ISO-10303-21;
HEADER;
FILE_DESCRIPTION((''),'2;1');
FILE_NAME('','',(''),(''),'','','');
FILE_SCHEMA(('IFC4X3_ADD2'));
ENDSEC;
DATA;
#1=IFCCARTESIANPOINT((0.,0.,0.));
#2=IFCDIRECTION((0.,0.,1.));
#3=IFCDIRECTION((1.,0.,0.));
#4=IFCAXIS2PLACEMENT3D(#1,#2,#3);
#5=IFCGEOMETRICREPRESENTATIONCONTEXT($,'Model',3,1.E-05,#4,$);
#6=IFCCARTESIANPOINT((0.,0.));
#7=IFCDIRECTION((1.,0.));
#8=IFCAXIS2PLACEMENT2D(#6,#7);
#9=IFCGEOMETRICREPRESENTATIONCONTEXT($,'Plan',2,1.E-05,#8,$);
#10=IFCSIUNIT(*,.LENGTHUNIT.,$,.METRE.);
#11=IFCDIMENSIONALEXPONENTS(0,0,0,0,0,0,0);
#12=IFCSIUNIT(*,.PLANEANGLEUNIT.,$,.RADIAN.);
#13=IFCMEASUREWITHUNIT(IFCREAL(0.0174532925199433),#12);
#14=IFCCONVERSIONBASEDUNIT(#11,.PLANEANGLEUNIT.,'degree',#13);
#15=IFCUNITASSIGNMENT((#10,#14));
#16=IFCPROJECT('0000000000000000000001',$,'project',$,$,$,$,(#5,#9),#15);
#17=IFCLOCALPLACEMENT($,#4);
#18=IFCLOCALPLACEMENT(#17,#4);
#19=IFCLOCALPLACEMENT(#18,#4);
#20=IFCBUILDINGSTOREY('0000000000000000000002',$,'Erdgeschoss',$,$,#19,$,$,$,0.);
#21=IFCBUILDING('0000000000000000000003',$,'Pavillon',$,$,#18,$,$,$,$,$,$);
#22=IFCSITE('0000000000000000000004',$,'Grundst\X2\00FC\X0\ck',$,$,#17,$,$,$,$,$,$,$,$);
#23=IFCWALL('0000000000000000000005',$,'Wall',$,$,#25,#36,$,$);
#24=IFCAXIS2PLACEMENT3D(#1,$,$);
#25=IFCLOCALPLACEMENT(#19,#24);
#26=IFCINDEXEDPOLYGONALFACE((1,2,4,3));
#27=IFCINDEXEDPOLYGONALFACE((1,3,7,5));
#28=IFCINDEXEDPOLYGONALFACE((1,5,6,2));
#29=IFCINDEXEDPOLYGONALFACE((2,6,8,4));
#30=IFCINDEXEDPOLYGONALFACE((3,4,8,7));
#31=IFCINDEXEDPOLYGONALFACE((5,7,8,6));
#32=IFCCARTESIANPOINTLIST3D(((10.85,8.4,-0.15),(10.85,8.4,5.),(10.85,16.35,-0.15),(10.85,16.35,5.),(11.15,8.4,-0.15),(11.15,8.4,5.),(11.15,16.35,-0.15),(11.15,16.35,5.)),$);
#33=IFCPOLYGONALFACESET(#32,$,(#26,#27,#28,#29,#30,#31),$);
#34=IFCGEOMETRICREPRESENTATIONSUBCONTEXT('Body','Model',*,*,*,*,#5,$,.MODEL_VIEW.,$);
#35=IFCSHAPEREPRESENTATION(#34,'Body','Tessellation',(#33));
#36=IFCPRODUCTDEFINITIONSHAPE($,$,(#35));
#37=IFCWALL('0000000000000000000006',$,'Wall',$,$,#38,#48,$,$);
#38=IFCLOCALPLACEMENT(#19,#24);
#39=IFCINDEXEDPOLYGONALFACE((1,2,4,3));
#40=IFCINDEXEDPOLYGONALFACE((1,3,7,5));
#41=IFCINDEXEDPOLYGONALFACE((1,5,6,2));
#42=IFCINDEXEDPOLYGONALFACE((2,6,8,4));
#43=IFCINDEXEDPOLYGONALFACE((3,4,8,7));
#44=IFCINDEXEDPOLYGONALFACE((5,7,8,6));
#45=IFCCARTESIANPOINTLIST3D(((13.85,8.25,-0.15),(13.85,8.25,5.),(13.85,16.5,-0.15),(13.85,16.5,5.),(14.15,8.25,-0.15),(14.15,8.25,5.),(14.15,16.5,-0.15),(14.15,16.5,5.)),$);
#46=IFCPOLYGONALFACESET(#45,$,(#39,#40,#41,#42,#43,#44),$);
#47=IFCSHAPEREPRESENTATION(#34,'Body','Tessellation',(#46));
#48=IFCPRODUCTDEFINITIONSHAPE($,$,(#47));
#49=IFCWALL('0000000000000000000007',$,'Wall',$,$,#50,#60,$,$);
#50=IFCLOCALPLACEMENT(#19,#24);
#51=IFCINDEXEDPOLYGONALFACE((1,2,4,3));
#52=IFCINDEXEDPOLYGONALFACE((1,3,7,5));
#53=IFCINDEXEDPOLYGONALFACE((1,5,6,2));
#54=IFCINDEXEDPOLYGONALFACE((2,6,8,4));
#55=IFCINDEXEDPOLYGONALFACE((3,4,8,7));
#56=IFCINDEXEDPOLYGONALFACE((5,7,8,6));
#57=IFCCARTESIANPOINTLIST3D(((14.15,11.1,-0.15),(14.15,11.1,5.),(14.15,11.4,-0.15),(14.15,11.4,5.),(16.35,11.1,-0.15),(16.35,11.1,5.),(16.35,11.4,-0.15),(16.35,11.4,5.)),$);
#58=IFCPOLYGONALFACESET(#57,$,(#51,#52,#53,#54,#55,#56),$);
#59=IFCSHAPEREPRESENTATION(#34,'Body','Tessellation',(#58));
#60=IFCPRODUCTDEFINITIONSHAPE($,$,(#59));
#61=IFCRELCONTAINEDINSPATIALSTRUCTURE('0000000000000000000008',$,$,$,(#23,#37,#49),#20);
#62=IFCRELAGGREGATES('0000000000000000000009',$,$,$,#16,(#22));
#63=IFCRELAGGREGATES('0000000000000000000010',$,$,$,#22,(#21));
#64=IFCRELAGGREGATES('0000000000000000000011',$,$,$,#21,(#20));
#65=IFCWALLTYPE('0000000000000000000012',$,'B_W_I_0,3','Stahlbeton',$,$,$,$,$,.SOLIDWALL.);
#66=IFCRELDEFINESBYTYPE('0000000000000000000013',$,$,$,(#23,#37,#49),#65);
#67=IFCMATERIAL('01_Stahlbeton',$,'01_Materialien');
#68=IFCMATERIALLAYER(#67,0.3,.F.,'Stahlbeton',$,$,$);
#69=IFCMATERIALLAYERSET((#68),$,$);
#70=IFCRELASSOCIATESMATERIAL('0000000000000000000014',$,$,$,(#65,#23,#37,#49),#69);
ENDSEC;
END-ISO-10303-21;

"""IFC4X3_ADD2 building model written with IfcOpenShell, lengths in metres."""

from ifc_helpers import new_model, entity, si_unit, converted_unit, frame, origin_with_axes, origin_2d_with_axis, place, context, subcontext, project, spatial, line, indexed_curve, outline, extrude, material, layer, layer_set, layer_usage, type_object, element, save


model = new_model("IFC4X3_ADD2")

# Units and contexts
model_context = context("Model", 3, precision=1e-05, world=origin_with_axes())
plan_context = context("Plan", 2, precision=1e-05, world=origin_2d_with_axis())
body_context = subcontext(model_context, "Body", "Model", "MODEL_VIEW")
ifc_project = project(units=[si_unit("LENGTHUNIT", "METRE"), converted_unit("PLANEANGLEUNIT", "degree", entity("IfcReal", 0.0174532925199433), si_unit("PLANEANGLEUNIT", "RADIAN"), dimensions=[0, 0, 0, 0, 0, 0, 0])], contexts=[model_context, plan_context])

# Site, building, storey
site_placement = place(None, origin_with_axes())
site = spatial("IfcSite", under=ifc_project, at=site_placement, Name="Grundstück")
building_placement = place(site_placement, origin_with_axes())
building = spatial("IfcBuilding", under=site, at=building_placement, Name="Pavillon")
storey_placement = place(building_placement, origin_with_axes())
storey = spatial("IfcBuildingStorey", under=building, at=storey_placement, Name="Erdgeschoss", Elevation=0.0)

# Walls
ifc_material_1 = material(Name="01_Stahlbeton", Category="01_Materialien")
ifc_layer = layer(ifc_material_1, 0.3, ventilated=False, Name="Stahlbeton")
ifc_layer_set = layer_set([ifc_layer])
wall_type = type_object("IfcWallType", Name="B_W_I_0,3", Description="Stahlbeton", PredefinedType="SOLIDWALL", material=ifc_layer_set)
ifc_layer_usage_1 = layer_usage(ifc_layer_set, "AXIS2", "POSITIVE", -0.15)
wall_1_placement = place(storey_placement, frame((11.0, 16.5, -0.15), z_axis=(0.0, 0.0, 1.0), x_axis=(0.0, -1.0, 0.0)))
element("IfcWall", 1, at=wall_1_placement, inside=storey, type_object=wall_type, material=ifc_layer_usage_1, Name="Wall", context=body_context, shape_type="SweptSolid", body=[
    extrude(outline(indexed_curve([(0.15, -0.15), (0.15, 0.15), (8.1, 0.15), (8.1, -0.15)], segments=[line(1, 2, 3, 4, 1)])), origin_with_axes(), (0.0, 0.0, 1.0), 5.15),
])
ifc_layer_usage_2 = layer_usage(ifc_layer_set, "AXIS2", "POSITIVE", -0.15)
wall_2_placement = place(storey_placement, frame((14.0, 16.5, -0.15), z_axis=(0.0, 0.0, 1.0), x_axis=(0.0, -1.0, 0.0)))
element("IfcWall", 2, at=wall_2_placement, inside=storey, type_object=wall_type, material=ifc_layer_usage_2, Name="Wall", context=body_context, shape_type="SweptSolid", body=[
    extrude(outline(indexed_curve([(0.0, -0.15), (0.0, 0.15), (8.25, 0.15), (8.25, -0.15)], segments=[line(1, 2, 3, 4, 1)])), origin_with_axes(), (0.0, 0.0, 1.0), 5.15),
])
ifc_layer_usage_3 = layer_usage(ifc_layer_set, "AXIS2", "POSITIVE", -0.15)
wall_3_placement = place(storey_placement, frame((14.0, 11.25, -0.15), z_axis=(0.0, 0.0, 1.0), x_axis=(1.0, 0.0, 0.0)))
element("IfcWall", 3, at=wall_3_placement, inside=storey, type_object=wall_type, material=ifc_layer_usage_3, Name="Wall", context=body_context, shape_type="SweptSolid", body=[
    extrude(outline(indexed_curve([(0.15, -0.15), (0.15, 0.15), (2.35, 0.15), (2.35, -0.15)], segments=[line(1, 2, 3, 4, 1)])), origin_with_axes(), (0.0, 0.0, 1.0), 5.15),
])

save(model, "model.ifc")
